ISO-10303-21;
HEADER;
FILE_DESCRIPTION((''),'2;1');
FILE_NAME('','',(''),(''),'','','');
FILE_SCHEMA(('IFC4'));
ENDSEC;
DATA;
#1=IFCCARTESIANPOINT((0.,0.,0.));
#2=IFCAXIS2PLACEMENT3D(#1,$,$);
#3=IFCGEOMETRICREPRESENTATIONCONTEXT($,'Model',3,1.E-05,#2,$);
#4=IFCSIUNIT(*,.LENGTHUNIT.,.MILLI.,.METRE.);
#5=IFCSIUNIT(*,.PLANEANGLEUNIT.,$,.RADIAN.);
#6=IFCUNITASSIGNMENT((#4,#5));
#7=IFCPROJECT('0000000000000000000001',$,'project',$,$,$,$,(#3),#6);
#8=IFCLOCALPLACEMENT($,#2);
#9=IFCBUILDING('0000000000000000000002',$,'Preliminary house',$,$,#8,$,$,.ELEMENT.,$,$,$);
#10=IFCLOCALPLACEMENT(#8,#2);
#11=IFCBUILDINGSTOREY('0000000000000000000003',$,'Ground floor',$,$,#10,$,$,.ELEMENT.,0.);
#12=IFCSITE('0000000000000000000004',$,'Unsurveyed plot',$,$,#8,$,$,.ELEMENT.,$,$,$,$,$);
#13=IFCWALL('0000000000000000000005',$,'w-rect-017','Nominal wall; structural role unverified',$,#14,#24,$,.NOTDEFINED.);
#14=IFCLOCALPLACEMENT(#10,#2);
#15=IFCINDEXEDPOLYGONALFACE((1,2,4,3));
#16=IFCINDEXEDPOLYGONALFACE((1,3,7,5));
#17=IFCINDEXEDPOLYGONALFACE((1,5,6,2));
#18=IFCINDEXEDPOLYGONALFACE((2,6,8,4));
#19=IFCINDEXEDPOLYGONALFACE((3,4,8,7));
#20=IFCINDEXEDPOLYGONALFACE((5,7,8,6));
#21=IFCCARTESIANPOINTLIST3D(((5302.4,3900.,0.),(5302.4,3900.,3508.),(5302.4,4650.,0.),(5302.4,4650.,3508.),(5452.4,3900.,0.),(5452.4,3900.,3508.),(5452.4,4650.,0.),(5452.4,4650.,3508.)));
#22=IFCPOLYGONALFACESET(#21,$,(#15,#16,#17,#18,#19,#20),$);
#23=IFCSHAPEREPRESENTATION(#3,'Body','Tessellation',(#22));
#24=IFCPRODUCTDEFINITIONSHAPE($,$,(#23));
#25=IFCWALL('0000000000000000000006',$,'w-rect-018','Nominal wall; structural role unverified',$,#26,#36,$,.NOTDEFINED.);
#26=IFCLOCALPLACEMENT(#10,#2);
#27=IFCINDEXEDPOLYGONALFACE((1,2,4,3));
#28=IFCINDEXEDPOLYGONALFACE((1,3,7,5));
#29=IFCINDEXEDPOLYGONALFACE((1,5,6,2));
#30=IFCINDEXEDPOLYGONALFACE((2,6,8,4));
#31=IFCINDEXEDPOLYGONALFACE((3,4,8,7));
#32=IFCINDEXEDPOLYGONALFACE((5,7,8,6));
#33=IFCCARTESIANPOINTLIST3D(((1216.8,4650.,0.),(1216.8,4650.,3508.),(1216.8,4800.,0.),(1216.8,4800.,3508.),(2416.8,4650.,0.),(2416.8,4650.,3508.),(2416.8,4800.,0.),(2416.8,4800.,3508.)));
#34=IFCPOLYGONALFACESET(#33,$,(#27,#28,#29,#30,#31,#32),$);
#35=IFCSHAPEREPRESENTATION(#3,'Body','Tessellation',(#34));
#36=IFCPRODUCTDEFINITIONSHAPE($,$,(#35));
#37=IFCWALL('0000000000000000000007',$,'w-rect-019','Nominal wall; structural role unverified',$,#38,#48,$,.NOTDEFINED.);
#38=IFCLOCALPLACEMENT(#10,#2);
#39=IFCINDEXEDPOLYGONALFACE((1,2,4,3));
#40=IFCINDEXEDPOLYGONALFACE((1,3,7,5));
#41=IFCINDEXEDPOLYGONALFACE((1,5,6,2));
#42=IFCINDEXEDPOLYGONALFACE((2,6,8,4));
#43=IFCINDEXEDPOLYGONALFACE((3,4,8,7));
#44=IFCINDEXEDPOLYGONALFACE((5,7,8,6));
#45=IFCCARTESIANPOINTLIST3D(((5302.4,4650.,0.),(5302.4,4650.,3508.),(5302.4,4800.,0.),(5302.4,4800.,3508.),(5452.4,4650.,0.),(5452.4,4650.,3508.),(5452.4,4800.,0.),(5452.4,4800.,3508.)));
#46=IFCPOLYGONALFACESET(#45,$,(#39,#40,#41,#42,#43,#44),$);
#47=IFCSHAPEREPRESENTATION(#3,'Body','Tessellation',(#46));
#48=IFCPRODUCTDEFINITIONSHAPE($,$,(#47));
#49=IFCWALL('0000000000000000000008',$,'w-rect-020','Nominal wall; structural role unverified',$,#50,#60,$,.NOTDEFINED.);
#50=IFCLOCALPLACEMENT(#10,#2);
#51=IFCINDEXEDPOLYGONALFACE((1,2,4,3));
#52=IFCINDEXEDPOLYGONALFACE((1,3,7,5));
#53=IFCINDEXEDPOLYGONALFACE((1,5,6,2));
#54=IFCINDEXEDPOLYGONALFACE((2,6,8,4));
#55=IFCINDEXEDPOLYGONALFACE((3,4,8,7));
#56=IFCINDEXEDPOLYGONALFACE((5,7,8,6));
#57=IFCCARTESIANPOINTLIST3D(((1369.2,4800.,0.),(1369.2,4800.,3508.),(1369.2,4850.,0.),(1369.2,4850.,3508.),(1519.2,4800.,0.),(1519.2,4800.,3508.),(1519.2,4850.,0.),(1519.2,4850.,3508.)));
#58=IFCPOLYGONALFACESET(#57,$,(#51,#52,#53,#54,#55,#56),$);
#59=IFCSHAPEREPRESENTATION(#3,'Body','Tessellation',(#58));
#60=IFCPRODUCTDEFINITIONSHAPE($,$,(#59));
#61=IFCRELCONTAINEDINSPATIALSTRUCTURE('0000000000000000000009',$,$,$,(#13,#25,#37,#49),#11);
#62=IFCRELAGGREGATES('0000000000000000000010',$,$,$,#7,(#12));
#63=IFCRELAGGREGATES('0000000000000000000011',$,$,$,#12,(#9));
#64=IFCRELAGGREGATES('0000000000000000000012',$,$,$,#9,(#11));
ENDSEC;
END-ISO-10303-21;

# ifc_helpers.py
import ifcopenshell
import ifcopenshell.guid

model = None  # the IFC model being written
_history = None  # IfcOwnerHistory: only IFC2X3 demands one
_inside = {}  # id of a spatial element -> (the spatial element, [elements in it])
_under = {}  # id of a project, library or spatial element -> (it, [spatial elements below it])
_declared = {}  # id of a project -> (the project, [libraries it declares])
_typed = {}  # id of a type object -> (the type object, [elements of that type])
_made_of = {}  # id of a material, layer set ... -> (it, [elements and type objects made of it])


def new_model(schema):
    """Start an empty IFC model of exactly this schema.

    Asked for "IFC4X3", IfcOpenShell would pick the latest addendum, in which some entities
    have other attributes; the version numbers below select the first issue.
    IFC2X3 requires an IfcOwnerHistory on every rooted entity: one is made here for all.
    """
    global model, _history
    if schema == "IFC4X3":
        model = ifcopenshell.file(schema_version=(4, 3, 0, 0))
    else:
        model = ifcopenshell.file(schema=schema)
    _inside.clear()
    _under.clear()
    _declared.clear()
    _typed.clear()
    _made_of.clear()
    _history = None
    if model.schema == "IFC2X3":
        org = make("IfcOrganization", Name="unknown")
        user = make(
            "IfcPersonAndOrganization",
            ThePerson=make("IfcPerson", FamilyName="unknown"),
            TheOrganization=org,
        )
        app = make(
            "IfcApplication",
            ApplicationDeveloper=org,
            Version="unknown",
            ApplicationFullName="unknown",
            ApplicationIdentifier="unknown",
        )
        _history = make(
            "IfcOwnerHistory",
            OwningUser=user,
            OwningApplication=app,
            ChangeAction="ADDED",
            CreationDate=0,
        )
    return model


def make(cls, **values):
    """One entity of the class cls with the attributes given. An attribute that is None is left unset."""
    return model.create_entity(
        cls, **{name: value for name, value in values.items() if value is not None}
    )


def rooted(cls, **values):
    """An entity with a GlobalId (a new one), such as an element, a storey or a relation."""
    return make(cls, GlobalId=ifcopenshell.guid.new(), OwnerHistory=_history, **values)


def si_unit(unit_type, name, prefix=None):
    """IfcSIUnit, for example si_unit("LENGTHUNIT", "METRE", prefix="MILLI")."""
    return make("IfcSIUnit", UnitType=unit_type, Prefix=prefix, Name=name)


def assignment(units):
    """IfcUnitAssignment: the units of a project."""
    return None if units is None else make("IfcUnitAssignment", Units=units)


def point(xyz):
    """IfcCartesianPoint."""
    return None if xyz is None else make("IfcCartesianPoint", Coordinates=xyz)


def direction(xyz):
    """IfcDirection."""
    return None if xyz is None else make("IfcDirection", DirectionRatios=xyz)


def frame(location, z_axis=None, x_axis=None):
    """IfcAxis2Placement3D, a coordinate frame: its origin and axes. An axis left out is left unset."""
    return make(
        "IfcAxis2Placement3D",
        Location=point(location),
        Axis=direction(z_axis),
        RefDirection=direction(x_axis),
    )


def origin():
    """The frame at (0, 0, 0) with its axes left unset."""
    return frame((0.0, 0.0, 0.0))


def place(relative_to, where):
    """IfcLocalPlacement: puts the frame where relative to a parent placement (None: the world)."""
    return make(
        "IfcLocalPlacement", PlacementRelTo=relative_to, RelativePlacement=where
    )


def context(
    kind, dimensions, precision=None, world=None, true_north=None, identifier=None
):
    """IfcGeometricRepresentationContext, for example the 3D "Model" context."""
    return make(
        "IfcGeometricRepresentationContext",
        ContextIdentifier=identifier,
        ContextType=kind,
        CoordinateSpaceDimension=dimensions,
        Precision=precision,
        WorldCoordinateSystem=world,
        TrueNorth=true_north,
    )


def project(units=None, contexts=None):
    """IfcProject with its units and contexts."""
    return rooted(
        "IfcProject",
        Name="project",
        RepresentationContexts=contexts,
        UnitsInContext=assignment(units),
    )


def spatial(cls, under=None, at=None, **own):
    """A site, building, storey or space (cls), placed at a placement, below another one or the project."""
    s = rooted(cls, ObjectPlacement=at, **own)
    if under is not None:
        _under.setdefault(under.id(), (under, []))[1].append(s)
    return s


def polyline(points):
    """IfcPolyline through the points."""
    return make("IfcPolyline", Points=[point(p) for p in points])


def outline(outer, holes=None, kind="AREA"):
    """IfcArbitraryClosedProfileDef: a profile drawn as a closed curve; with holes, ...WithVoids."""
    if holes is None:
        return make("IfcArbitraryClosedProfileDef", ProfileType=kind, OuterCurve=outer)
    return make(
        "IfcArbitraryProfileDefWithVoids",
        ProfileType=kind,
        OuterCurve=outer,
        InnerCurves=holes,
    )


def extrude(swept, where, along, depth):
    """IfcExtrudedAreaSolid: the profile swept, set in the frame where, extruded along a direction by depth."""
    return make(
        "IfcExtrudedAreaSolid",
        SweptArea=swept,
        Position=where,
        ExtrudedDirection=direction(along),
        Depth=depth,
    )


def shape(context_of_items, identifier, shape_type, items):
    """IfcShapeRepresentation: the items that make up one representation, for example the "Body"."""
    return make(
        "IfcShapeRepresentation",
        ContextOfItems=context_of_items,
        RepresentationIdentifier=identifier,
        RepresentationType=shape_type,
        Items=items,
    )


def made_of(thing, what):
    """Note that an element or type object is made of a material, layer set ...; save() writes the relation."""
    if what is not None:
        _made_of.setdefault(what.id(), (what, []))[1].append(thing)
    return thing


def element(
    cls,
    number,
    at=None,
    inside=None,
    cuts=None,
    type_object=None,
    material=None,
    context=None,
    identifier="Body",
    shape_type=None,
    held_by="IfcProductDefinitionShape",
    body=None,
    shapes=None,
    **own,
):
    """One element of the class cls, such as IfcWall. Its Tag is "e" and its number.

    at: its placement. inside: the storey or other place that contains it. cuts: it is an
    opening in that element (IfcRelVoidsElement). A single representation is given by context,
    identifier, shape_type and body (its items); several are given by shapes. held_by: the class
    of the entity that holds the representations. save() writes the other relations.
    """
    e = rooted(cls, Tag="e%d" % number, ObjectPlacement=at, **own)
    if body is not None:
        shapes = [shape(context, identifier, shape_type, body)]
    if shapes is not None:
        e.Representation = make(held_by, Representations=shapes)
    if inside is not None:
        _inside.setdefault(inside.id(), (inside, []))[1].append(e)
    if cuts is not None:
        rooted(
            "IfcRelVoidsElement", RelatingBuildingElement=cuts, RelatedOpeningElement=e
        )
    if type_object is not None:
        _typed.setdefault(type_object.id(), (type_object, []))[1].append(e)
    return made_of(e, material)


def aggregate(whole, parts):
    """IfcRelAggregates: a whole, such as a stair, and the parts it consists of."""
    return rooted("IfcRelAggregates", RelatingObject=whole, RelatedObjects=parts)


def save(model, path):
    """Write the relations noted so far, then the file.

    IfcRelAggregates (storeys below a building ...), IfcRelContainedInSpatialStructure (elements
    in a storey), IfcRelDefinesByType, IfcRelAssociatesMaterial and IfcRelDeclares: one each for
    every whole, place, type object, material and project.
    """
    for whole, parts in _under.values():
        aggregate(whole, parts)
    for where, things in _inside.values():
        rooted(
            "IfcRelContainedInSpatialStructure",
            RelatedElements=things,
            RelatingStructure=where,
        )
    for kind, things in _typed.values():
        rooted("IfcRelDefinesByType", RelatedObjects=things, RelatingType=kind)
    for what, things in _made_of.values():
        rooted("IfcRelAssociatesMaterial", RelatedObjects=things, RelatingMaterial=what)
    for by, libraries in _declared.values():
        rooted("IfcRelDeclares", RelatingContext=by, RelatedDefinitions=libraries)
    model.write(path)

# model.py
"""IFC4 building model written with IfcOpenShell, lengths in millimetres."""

from ifc_helpers import new_model, si_unit, origin, place, context, project, spatial, polyline, outline, extrude, element, save


model = new_model("IFC4")

# Units and contexts
model_context = context("Model", 3, precision=1e-05, world=origin())
ifc_project = project(units=[si_unit("LENGTHUNIT", "METRE", prefix="MILLI"), si_unit("PLANEANGLEUNIT", "RADIAN")], contexts=[model_context])

# Site, building, storey
placement_1 = place(None, origin())
site = spatial("IfcSite", under=ifc_project, at=placement_1, Name="Unsurveyed plot", CompositionType="ELEMENT")
building = spatial("IfcBuilding", under=site, at=placement_1, Name="Preliminary house", CompositionType="ELEMENT")
placement_2 = place(placement_1, origin())
storey = spatial("IfcBuildingStorey", under=building, at=placement_2, Name="Ground floor", CompositionType="ELEMENT", Elevation=0.0)

# Walls
element("IfcWall", 1, at=placement_2, inside=storey, Name="w-rect-017", Description="Nominal wall; structural role unverified", PredefinedType="NOTDEFINED", context=model_context, shape_type="SweptSolid", body=[
    extrude(outline(polyline([(5302.4, 3900.0), (5452.4, 3900.0), (5452.4, 4650.0), (5302.4, 4650.0), (5302.4, 3900.0)])), origin(), (0.0, 0.0, 1.0), 3508.0),
])
element("IfcWall", 2, at=placement_2, inside=storey, Name="w-rect-018", Description="Nominal wall; structural role unverified", PredefinedType="NOTDEFINED", context=model_context, shape_type="SweptSolid", body=[
    extrude(outline(polyline([(1216.8, 4650.0), (2416.8, 4650.0), (2416.8, 4800.0), (1216.8, 4800.0), (1216.8, 4650.0)])), origin(), (0.0, 0.0, 1.0), 3508.0),
])
element("IfcWall", 3, at=placement_2, inside=storey, Name="w-rect-019", Description="Nominal wall; structural role unverified", PredefinedType="NOTDEFINED", context=model_context, shape_type="SweptSolid", body=[
    extrude(outline(polyline([(5302.4, 4650.0), (5452.4, 4650.0), (5452.4, 4800.0), (5302.4, 4800.0), (5302.4, 4650.0)])), origin(), (0.0, 0.0, 1.0), 3508.0),
])
element("IfcWall", 4, at=placement_2, inside=storey, Name="w-rect-020", Description="Nominal wall; structural role unverified", PredefinedType="NOTDEFINED", context=model_context, shape_type="SweptSolid", body=[
    extrude(outline(polyline([(1369.2, 4800.0), (1519.2, 4800.0), (1519.2, 4850.0), (1369.2, 4850.0), (1369.2, 4800.0)])), origin(), (0.0, 0.0, 1.0), 3508.0),
])

save(model, "model.ifc")
